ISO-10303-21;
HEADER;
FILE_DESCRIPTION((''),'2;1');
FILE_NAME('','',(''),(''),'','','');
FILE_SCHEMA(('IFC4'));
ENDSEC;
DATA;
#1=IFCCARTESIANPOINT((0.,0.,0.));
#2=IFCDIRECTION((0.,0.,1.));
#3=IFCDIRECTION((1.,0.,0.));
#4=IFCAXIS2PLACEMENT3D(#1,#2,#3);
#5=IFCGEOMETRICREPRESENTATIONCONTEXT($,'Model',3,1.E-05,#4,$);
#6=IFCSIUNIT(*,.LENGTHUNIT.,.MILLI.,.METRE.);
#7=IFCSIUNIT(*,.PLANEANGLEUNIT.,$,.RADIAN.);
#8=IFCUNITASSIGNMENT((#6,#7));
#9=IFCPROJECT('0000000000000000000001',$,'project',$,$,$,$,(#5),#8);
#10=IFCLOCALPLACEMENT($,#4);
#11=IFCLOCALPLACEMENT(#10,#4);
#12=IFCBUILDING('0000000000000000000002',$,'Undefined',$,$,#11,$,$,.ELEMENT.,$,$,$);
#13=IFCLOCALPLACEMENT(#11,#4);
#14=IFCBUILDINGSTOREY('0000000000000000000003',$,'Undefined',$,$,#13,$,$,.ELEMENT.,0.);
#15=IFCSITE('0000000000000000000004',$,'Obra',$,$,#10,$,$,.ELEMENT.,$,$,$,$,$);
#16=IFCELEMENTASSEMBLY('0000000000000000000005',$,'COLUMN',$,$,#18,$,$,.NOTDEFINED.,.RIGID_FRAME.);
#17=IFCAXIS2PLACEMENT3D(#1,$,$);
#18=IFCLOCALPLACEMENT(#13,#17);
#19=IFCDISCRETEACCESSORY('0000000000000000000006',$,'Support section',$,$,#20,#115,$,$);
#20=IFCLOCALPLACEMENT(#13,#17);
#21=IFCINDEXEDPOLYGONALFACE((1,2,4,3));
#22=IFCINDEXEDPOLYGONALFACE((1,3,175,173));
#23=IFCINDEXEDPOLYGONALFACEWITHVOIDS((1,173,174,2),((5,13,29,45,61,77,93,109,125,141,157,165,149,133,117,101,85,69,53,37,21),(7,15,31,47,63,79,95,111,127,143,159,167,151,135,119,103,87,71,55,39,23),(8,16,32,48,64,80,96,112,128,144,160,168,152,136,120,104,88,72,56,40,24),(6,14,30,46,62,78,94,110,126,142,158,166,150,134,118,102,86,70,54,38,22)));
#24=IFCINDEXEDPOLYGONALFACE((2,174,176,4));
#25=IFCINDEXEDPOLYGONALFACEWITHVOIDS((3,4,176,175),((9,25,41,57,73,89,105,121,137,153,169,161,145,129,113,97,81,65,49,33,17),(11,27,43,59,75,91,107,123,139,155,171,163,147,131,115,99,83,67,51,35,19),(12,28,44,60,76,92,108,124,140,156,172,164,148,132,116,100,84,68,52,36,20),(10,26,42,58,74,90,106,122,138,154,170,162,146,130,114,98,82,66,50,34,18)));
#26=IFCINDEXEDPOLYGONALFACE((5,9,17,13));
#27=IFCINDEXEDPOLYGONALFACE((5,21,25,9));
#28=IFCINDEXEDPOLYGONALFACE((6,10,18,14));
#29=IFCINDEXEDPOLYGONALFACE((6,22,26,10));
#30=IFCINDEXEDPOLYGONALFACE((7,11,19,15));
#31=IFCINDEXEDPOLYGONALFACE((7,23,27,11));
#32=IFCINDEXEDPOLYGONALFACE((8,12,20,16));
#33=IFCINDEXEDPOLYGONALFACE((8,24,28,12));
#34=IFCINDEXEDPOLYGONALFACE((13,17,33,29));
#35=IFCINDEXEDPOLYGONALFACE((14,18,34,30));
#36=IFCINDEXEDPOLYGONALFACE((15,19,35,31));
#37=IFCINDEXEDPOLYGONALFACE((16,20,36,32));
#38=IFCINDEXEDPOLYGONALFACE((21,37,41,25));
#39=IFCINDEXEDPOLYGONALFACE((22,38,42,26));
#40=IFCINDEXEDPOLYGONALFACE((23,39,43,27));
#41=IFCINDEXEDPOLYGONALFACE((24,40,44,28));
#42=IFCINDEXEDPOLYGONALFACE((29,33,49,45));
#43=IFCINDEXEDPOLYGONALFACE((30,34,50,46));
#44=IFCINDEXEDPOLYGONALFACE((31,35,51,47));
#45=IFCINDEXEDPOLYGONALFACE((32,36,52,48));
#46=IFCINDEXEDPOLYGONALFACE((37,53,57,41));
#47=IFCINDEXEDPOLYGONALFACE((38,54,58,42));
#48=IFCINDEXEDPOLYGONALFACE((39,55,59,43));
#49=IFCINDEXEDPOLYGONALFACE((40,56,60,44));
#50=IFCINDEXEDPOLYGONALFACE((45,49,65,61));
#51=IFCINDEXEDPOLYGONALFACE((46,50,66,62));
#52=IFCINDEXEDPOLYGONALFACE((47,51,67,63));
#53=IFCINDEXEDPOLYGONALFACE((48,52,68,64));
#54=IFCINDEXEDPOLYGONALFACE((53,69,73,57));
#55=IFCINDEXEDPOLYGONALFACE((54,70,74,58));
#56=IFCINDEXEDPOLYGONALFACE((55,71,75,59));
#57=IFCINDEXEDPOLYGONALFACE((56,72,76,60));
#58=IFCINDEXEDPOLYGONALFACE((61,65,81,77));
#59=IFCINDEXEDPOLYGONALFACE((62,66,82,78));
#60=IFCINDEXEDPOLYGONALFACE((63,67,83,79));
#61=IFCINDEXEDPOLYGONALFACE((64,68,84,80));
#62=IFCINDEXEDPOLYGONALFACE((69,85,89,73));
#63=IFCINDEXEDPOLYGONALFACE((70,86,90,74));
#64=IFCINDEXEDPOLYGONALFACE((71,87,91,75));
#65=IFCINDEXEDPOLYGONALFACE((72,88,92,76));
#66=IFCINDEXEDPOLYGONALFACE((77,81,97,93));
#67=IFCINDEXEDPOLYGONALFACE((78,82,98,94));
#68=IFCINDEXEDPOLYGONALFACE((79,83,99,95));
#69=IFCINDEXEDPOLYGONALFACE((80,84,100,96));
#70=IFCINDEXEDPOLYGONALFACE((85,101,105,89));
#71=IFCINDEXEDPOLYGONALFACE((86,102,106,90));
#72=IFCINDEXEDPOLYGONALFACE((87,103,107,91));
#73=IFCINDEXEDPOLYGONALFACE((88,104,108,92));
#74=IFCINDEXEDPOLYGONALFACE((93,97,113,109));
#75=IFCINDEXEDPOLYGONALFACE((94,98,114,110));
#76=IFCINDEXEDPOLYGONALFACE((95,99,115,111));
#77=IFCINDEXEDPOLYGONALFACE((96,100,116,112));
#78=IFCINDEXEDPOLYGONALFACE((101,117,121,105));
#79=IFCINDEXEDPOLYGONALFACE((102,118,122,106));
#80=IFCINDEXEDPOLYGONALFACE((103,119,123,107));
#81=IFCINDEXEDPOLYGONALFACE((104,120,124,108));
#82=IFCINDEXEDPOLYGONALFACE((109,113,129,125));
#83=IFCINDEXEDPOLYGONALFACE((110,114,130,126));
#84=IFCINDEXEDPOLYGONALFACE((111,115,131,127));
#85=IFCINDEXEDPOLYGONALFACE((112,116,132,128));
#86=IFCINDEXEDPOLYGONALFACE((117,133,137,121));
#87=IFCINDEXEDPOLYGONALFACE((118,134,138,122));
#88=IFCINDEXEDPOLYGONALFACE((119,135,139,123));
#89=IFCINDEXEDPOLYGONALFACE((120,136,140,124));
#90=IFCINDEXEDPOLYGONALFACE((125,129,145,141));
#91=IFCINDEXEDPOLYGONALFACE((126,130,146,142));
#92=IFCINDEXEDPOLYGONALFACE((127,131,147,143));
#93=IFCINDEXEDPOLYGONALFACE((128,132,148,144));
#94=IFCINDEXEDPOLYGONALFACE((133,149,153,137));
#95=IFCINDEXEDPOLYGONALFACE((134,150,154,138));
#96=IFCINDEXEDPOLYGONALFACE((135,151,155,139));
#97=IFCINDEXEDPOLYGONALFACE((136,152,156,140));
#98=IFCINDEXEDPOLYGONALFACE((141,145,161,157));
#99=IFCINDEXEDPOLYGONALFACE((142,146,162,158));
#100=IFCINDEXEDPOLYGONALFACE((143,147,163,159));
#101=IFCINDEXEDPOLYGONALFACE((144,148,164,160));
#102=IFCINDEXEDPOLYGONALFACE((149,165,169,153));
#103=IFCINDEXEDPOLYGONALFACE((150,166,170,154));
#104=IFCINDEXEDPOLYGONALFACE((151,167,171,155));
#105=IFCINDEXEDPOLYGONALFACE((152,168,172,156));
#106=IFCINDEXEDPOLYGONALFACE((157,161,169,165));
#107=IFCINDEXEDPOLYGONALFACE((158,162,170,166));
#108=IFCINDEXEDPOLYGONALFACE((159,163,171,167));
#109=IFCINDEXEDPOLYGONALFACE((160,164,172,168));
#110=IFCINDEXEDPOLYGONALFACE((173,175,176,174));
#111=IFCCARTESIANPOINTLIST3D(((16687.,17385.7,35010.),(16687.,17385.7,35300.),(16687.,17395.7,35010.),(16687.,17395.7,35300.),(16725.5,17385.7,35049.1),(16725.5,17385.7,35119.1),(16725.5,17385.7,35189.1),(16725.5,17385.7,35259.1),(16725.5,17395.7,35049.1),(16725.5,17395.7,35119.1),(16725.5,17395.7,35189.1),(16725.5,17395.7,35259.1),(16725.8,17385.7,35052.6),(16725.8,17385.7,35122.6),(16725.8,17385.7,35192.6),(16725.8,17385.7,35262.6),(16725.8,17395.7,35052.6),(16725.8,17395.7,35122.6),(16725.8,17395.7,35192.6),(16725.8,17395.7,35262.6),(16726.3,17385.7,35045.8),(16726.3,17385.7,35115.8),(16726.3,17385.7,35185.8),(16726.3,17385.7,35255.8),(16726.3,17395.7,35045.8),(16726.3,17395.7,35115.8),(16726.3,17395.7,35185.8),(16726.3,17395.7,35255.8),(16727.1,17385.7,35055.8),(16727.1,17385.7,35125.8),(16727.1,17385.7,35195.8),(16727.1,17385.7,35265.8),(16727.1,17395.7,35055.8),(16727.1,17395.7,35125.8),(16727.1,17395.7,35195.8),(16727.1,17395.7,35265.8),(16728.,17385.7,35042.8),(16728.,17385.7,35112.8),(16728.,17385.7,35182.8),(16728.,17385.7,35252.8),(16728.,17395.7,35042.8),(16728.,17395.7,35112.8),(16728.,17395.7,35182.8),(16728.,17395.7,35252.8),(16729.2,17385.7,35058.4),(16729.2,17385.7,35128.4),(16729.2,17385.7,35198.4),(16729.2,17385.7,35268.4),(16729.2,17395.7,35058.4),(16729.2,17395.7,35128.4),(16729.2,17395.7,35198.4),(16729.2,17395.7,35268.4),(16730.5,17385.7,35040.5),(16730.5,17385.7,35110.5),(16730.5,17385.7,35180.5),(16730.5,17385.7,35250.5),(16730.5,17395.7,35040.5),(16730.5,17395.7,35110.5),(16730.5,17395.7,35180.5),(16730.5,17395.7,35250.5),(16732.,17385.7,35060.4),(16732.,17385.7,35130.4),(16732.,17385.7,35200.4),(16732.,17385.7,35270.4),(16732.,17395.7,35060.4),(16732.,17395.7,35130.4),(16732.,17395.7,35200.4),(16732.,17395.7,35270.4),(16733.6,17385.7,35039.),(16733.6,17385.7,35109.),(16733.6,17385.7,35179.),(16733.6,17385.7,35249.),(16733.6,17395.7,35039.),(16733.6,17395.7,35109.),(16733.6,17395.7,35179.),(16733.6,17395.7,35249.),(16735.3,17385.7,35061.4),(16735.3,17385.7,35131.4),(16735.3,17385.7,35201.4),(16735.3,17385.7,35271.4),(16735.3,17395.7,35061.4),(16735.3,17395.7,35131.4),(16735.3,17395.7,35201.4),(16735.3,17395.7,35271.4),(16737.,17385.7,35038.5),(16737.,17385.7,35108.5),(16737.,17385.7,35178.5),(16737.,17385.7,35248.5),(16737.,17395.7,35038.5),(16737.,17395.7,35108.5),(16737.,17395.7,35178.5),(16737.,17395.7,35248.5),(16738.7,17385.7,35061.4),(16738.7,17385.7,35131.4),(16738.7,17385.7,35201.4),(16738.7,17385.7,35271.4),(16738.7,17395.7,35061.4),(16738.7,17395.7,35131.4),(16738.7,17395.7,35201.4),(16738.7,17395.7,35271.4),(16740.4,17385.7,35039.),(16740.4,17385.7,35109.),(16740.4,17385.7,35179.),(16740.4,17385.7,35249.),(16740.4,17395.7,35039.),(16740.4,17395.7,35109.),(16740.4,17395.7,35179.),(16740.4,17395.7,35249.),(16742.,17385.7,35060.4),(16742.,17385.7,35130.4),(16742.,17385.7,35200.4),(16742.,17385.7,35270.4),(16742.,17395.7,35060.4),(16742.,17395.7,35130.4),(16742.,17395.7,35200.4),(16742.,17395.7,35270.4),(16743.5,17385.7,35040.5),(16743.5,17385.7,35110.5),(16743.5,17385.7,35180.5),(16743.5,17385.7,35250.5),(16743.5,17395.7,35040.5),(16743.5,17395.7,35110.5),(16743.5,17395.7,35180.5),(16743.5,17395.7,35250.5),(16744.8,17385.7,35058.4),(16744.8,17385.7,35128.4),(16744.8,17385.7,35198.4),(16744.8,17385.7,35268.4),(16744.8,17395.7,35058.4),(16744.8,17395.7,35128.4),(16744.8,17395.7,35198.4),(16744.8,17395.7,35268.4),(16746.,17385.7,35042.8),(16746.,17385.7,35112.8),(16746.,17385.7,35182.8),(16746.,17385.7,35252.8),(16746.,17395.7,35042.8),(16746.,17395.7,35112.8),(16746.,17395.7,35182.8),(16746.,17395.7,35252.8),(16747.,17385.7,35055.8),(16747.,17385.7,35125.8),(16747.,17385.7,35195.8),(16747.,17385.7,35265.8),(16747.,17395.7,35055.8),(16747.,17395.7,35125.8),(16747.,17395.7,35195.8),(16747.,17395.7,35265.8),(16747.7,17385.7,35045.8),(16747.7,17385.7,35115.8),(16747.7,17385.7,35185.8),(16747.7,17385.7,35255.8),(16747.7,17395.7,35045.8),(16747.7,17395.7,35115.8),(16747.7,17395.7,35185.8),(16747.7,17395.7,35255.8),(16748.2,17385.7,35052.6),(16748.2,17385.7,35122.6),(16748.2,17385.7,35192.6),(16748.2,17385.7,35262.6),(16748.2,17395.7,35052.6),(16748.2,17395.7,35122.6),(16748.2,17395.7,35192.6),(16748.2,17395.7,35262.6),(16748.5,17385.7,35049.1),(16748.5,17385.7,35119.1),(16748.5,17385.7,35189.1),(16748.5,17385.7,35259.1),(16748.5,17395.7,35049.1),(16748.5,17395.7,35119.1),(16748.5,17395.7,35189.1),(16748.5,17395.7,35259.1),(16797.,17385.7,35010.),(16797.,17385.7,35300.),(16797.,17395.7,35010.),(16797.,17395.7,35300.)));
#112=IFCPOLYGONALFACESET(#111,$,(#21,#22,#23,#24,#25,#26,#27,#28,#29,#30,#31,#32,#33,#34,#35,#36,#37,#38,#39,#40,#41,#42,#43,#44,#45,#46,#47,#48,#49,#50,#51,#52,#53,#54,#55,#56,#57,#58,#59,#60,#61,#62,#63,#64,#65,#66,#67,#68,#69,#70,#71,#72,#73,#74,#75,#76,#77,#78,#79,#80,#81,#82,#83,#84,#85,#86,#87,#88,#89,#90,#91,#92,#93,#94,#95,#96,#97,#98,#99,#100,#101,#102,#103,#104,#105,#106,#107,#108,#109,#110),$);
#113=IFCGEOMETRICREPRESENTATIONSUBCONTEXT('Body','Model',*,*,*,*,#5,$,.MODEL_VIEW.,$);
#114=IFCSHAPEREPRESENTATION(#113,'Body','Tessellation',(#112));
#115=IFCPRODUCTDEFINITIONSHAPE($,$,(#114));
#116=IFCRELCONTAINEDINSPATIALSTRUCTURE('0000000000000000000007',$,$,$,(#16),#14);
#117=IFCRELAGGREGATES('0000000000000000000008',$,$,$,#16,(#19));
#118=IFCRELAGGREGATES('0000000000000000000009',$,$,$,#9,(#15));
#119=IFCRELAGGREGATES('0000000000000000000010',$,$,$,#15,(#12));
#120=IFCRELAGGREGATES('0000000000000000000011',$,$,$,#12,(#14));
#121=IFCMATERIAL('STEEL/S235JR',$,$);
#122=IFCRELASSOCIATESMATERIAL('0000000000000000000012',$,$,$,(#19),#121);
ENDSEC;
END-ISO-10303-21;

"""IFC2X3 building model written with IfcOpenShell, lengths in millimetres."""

from ifc_helpers import new_model, si_unit, frame, origin_with_axes, origin_2d_with_axis, place, context, subcontext, project, spatial, rectangle, circle, extrude, source, transform, mapped, material, element, aggregate, save


model = new_model("IFC2X3")

# Units and contexts
model_context = context("Model", 3, precision=1e-05, world=origin_with_axes())
body_context = subcontext(model_context, "Body", "Model", "MODEL_VIEW")
ifc_project = project(units=[si_unit("LENGTHUNIT", "METRE", prefix="MILLI"), si_unit("PLANEANGLEUNIT", "RADIAN")], contexts=[model_context])

# Site, building, storey
site_placement = place(None, origin_with_axes())
site = spatial("IfcSite", under=ifc_project, at=site_placement, Name="Obra", CompositionType="ELEMENT")
building_placement = place(site_placement, origin_with_axes())
building = spatial("IfcBuilding", under=site, at=building_placement, Name="Undefined", CompositionType="ELEMENT")
storey_placement = place(building_placement, origin_with_axes())
storey = spatial("IfcBuildingStorey", under=building, at=storey_placement, Name="Undefined", CompositionType="ELEMENT", Elevation=0.0)

# Element assembly, discrete accessory, opening
ifc_material_1 = material(Name="STEEL/S235JR")
assembly_1_placement = place(storey_placement, origin_with_axes())
assembly_1 = element("IfcElementAssembly", 1, at=assembly_1_placement, inside=storey, Name="COLUMN", AssemblyPlace="NOTDEFINED", PredefinedType="RIGID_FRAME")
discrete_accessory_1_placement = place(assembly_1_placement, frame((16742.0, 17390.7, 35010.0), z_axis=(0.0, 0.0, 1.0), x_axis=(1.0, 0.0, 0.0)))
discrete_accessory_1 = element("IfcDiscreteAccessory", 2, at=discrete_accessory_1_placement, material=ifc_material_1, Name="Support section", context=body_context, shape_type="SweptSolid", body=[
    extrude(rectangle(XDim=10.0, YDim=110.0, at=origin_2d_with_axis()), frame((0.0, 0.0, 290.0), z_axis=(0.0, 0.0, -1.0), x_axis=(0.0, 1.0, 0.0)), (0.0, 0.0, 1.0), 290.0),
])
shared_shape_1 = source(origin_with_axes(), body_context, "Body", "SweptSolid", [
    extrude(circle(Radius=11.5, at=origin_2d_with_axis()), frame((0.0, -15.6, 0.0), z_axis=(0.0, 1.0, 0.0), x_axis=(1.0, 0.0, 0.0)), (0.0, 0.0, 1.0), 10.2),
])
opening_1_placement = place(assembly_1_placement, frame((16787.0, 17380.2, 35350.0), z_axis=(-1.0, 0.0, 0.0), x_axis=(0.0, 0.0, -1.0)))
element("IfcOpeningElement", 3, at=opening_1_placement, cuts=discrete_accessory_1, ObjectType="Opening", context=body_context, shape_type="MappedRepresentation", body=[
    mapped(shared_shape_1, transform((90.0, 0.0, 50.0))),
    mapped(shared_shape_1, transform((160.0, 0.0, 50.0))),
    mapped(shared_shape_1, transform((230.0, 0.0, 50.0))),
    mapped(shared_shape_1, transform((300.0, 0.0, 50.0))),
])
aggregate(assembly_1, [discrete_accessory_1])

save(model, "model.ifc")
